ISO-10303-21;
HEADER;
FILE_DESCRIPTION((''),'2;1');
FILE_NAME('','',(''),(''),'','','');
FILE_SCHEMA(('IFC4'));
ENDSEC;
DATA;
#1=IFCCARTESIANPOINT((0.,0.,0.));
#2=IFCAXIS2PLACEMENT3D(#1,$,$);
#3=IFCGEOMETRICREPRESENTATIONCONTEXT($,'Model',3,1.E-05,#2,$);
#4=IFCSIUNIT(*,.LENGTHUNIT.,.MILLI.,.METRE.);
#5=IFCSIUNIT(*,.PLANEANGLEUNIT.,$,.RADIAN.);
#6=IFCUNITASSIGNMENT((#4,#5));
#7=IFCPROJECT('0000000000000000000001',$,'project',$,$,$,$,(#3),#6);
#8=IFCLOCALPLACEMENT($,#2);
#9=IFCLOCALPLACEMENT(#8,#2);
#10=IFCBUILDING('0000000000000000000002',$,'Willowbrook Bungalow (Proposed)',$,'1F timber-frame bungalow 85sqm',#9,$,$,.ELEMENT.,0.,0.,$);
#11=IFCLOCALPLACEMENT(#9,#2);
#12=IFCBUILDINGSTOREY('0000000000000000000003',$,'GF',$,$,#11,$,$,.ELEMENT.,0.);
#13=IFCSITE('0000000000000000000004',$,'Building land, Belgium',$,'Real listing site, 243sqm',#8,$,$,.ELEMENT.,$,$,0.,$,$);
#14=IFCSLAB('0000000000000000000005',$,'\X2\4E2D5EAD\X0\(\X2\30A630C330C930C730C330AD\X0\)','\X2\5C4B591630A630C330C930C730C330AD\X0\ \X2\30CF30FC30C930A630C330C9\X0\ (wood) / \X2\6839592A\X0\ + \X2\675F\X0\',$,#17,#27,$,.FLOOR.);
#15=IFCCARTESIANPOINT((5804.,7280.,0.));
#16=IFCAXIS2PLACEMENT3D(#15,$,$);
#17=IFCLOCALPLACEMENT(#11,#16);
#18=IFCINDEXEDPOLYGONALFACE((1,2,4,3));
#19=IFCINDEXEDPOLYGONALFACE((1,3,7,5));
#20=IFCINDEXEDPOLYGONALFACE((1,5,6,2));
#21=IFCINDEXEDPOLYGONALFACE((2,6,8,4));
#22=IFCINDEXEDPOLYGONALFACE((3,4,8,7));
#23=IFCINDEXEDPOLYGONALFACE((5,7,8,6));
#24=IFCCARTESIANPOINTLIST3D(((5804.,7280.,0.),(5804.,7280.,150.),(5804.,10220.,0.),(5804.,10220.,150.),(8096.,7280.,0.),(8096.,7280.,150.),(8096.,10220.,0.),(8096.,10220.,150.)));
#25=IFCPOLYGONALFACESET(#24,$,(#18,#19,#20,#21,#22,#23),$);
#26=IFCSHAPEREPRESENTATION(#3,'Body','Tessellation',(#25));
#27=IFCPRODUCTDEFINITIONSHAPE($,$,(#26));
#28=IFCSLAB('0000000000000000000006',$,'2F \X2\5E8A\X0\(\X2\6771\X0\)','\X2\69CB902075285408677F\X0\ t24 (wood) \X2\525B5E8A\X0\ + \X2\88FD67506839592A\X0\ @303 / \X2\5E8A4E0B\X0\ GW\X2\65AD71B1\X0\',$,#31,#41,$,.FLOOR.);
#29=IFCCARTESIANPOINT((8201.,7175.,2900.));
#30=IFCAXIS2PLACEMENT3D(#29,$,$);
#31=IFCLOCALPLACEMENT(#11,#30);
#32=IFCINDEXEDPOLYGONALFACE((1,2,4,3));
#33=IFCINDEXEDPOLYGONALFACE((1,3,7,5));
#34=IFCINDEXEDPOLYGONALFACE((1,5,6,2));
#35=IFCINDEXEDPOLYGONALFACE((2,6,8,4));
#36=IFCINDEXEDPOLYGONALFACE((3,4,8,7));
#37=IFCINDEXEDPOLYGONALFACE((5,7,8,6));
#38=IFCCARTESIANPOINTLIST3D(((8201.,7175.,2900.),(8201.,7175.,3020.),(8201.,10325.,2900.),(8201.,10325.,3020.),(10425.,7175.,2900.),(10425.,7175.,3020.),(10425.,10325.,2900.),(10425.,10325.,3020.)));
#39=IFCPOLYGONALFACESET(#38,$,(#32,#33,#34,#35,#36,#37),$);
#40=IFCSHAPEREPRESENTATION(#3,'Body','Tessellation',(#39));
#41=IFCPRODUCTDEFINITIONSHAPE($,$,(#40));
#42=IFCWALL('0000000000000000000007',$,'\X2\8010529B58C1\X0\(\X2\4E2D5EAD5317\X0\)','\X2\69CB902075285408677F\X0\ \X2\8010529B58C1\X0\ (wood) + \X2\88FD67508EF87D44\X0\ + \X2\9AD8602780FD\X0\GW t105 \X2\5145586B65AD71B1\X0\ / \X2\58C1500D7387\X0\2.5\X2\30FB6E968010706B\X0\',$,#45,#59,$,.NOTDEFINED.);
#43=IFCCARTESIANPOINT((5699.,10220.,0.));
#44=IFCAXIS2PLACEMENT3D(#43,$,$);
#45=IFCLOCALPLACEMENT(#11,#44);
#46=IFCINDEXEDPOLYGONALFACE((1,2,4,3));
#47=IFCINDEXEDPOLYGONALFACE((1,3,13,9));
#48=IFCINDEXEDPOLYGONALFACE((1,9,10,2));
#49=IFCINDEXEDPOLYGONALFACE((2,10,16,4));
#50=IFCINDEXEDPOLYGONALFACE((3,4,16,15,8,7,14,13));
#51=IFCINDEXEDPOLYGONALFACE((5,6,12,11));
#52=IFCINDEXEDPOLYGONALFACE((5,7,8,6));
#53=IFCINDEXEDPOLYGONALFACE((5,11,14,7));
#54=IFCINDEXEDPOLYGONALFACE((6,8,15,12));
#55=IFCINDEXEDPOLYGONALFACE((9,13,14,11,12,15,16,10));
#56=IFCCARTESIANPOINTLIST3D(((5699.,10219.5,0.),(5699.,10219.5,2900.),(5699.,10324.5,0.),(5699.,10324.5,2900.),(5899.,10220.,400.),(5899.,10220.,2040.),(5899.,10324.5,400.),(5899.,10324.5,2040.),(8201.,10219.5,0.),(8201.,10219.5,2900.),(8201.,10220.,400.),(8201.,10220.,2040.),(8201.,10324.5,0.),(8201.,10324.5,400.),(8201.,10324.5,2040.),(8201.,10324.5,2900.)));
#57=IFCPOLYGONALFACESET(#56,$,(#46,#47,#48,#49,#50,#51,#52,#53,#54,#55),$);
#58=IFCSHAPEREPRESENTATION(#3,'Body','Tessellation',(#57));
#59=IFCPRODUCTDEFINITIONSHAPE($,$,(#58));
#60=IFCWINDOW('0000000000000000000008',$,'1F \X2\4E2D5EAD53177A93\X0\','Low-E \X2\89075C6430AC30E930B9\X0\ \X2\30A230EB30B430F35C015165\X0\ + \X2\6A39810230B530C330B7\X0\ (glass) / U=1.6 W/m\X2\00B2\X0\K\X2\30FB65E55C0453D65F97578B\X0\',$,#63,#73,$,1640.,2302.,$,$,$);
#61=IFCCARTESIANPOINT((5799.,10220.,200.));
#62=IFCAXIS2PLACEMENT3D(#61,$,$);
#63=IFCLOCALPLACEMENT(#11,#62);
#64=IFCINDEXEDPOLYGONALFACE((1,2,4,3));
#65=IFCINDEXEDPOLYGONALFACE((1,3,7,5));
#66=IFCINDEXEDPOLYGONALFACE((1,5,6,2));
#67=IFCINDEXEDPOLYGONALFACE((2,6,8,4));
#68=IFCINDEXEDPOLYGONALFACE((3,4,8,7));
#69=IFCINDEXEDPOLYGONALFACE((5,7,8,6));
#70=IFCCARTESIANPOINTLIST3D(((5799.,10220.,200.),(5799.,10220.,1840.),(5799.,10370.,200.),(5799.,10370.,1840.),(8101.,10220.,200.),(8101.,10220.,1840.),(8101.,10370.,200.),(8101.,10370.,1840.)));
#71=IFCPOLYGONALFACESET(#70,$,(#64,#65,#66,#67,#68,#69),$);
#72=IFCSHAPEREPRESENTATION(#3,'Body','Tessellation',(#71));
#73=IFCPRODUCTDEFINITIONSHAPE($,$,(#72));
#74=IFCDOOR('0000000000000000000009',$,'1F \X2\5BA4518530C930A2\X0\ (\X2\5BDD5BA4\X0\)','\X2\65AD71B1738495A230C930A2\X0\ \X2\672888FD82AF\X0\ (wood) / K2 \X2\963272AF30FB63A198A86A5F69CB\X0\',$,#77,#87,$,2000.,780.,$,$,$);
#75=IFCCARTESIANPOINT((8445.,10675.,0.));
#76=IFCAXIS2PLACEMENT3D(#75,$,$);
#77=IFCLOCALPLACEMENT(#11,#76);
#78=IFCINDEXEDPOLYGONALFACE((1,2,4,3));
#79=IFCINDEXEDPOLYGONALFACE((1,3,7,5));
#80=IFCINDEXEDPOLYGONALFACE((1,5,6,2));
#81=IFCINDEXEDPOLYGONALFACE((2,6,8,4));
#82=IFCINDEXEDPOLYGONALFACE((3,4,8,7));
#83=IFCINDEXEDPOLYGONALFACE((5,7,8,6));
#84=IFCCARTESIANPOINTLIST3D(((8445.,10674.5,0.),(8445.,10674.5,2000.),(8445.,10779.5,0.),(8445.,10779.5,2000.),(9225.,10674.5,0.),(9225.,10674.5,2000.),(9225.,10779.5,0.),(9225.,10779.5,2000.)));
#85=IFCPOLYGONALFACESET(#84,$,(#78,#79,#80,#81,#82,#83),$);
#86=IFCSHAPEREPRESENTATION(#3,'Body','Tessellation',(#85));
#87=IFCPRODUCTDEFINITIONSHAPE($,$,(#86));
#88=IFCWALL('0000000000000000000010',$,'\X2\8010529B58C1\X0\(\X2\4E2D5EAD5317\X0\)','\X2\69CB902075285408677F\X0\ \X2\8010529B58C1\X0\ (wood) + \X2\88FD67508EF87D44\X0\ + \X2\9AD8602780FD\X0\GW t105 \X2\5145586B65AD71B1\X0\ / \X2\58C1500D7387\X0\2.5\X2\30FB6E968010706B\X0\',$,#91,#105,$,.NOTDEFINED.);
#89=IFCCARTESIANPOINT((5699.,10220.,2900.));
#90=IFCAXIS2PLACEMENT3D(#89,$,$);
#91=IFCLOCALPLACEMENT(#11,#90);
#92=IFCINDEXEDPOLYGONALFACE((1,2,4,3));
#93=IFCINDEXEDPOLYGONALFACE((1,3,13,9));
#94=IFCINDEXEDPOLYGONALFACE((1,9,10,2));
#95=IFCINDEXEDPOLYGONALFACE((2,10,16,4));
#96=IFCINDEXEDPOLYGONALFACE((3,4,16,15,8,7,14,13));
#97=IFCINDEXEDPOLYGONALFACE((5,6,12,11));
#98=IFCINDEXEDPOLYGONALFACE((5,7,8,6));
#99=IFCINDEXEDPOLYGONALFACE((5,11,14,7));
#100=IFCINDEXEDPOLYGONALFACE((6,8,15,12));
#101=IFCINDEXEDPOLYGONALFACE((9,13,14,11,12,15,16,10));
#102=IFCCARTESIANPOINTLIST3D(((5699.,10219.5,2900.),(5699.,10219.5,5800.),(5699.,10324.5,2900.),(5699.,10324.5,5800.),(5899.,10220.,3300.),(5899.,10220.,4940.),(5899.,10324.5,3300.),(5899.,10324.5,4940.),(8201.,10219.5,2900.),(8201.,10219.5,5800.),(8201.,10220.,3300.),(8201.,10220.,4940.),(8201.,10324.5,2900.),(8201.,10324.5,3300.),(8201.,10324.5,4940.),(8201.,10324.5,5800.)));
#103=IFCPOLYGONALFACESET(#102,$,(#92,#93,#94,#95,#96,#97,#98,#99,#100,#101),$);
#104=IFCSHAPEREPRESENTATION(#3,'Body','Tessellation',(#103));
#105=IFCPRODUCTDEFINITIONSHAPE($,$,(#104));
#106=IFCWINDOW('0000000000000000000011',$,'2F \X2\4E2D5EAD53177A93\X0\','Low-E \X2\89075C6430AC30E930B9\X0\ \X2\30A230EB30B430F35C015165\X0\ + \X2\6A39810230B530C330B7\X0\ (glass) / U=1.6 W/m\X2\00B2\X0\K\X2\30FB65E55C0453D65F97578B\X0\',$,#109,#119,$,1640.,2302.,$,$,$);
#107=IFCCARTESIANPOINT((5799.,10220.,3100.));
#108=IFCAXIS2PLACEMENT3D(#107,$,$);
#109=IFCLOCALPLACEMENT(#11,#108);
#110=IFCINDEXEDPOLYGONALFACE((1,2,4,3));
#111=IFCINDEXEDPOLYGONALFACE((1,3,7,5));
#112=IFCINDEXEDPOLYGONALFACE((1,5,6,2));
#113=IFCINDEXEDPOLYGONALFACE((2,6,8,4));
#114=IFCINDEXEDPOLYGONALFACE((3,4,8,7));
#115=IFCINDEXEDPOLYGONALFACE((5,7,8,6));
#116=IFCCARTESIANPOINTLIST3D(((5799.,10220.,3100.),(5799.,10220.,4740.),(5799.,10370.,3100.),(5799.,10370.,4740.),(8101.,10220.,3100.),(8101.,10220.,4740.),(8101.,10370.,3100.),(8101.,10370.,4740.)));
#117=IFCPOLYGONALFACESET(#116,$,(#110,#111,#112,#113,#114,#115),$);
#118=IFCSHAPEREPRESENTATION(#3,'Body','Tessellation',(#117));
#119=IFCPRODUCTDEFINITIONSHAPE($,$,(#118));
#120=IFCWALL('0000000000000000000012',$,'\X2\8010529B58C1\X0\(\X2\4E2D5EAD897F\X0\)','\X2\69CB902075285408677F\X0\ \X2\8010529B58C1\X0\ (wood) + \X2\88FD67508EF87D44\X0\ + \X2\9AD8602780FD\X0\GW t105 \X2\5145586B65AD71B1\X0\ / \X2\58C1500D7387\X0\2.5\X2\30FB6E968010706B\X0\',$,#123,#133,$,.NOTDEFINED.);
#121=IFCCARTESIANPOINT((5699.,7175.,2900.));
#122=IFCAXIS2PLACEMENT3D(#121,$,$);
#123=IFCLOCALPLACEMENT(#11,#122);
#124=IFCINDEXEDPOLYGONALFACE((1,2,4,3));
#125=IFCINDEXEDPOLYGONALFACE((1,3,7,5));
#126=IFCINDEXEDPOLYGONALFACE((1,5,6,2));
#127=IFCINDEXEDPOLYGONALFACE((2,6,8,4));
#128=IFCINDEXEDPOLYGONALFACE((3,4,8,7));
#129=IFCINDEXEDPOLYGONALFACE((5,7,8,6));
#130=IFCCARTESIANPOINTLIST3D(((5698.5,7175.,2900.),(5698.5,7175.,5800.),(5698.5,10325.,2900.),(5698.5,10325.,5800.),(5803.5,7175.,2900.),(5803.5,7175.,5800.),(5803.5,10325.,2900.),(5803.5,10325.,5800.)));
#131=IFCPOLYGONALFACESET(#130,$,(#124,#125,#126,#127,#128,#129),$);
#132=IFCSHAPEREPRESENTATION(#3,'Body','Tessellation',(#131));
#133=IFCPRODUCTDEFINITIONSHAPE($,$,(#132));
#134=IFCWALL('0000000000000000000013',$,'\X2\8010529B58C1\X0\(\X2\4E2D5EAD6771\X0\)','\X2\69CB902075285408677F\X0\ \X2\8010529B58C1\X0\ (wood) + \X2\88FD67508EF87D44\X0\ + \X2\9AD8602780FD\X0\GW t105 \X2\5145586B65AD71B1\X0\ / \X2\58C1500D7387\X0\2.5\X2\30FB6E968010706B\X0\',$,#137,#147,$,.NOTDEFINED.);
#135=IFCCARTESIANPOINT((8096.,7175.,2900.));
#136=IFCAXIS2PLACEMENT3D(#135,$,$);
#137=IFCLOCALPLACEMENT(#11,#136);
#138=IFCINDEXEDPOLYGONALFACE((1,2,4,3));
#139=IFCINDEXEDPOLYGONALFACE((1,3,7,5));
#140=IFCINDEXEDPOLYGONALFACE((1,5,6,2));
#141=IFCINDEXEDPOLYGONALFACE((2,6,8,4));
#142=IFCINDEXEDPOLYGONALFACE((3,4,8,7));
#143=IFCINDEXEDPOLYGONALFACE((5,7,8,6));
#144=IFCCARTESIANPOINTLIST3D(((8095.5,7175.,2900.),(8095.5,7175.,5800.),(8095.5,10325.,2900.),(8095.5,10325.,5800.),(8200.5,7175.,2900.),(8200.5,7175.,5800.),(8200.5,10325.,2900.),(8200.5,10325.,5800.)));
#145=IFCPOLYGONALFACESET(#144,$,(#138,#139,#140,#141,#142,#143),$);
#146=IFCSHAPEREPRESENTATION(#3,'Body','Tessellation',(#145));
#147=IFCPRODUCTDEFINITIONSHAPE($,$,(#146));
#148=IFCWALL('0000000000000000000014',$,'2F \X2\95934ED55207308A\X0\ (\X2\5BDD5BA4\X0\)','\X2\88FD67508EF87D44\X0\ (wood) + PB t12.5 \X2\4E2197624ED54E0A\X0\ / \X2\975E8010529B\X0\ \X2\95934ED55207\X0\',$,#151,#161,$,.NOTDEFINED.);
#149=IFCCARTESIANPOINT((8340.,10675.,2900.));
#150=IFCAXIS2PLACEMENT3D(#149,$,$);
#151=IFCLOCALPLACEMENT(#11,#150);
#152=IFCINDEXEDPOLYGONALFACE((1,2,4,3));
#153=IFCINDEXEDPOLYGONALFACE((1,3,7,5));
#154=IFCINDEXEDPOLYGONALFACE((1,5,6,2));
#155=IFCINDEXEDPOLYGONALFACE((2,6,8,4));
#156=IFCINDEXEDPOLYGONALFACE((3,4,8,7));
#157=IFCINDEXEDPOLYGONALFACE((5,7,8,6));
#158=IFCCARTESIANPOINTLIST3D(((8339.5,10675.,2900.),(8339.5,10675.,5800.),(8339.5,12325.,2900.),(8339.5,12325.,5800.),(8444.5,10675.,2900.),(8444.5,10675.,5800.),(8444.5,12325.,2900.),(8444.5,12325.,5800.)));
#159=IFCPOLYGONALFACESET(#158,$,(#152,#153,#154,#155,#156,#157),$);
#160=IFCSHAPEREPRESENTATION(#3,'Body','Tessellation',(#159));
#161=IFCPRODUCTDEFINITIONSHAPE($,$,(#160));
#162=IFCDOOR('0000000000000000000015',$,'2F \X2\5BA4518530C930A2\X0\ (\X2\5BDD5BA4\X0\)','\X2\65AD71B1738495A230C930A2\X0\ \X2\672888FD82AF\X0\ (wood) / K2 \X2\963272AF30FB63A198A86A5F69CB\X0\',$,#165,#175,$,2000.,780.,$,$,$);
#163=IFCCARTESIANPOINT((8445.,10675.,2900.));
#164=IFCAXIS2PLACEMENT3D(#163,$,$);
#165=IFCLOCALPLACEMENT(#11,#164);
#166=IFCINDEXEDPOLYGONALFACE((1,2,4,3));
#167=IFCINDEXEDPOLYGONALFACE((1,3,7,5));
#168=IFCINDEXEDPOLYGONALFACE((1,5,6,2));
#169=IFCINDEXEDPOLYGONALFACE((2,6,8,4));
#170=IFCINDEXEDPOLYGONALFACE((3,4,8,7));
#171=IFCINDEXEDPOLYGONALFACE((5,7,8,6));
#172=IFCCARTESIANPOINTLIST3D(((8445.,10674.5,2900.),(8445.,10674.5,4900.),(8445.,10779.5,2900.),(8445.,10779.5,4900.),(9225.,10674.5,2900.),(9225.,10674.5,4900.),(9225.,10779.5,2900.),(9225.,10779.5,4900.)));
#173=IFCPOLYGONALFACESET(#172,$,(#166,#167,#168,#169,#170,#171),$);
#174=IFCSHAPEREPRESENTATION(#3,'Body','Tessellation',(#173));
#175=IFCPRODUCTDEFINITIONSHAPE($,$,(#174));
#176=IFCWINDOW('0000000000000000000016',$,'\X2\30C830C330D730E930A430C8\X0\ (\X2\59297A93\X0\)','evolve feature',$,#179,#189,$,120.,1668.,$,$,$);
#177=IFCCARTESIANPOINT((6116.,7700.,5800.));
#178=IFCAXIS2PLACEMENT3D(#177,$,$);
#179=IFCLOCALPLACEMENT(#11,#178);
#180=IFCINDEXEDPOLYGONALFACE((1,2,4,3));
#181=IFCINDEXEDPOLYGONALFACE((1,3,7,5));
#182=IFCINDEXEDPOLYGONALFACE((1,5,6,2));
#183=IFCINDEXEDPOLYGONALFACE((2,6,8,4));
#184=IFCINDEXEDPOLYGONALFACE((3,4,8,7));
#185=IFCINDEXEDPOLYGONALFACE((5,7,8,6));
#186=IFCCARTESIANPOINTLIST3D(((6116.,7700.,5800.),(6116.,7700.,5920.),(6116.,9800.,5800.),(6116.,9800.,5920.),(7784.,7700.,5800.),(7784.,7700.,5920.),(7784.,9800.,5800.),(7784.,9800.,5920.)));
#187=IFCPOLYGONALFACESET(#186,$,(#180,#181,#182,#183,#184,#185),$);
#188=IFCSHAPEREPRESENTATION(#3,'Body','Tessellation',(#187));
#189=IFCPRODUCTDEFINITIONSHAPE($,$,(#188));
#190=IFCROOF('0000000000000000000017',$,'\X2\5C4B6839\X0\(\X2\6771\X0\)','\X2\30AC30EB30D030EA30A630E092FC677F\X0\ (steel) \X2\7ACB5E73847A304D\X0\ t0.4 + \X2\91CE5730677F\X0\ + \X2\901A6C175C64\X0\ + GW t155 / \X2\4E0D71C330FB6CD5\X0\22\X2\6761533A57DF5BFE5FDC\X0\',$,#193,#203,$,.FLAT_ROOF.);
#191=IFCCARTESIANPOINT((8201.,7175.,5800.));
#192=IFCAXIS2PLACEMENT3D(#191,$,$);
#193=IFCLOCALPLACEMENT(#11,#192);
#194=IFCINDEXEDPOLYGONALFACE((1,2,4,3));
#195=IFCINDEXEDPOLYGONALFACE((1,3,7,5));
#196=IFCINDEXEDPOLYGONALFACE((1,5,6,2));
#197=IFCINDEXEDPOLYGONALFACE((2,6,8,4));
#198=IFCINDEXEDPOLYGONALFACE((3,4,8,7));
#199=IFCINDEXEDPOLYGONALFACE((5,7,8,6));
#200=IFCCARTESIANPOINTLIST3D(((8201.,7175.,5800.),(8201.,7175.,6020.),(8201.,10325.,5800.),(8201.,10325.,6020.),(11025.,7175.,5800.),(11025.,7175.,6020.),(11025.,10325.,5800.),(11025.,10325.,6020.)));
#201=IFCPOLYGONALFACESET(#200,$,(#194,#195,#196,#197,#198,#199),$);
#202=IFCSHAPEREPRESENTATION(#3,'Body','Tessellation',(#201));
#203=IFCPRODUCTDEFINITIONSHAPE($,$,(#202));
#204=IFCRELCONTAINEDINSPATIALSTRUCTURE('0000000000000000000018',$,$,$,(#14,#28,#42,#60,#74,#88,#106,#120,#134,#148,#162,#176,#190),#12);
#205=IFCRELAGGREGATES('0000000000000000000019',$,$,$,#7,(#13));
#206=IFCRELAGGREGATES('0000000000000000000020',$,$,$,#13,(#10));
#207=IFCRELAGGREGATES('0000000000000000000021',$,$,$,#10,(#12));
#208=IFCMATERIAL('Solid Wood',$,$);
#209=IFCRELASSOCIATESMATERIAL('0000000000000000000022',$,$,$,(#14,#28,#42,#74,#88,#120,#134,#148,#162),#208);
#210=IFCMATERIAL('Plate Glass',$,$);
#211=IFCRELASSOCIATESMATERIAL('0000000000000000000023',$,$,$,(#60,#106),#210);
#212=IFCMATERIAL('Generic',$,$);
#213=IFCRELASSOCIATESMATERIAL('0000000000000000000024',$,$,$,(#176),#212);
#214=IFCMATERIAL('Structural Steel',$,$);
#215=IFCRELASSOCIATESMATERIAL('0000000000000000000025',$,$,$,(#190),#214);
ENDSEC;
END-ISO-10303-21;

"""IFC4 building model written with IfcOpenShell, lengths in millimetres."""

from ifc_helpers import new_model, si_unit, frame, frame_2d, origin, place, context, project, spatial, rectangle, extrude, material, element, fill, save


model = new_model("IFC4")

# Units and contexts
model_context = context("Model", 3, precision=1e-05, world=origin())
ifc_project = project(units=[si_unit("LENGTHUNIT", "METRE", prefix="MILLI"), si_unit("PLANEANGLEUNIT", "RADIAN")], contexts=[model_context])

# Site, building, storey
site_placement = place(None, origin())
site = spatial("IfcSite", under=ifc_project, at=site_placement, Name="Building land, Belgium", ObjectType="Real listing site, 243sqm", CompositionType="ELEMENT", RefElevation=0.0)
building_placement = place(site_placement, origin())
building = spatial("IfcBuilding", under=site, at=building_placement, Name="Willowbrook Bungalow (Proposed)", ObjectType="1F timber-frame bungalow 85sqm", CompositionType="ELEMENT", ElevationOfRefHeight=0.0, ElevationOfTerrain=0.0)
storey_placement = place(building_placement, origin())
storey = spatial("IfcBuildingStorey", under=building, at=storey_placement, Name="GF", CompositionType="ELEMENT", Elevation=0.0)

# Slabs
ifc_material_1 = material(Name="Solid Wood")
slab_1_placement = place(storey_placement, frame((5804.0, 7280.0, 0.0)))
element("IfcSlab", 1, at=slab_1_placement, inside=storey, material=ifc_material_1, Name="中庭(ウッドデッキ)", Description="屋外ウッドデッキ ハードウッド (wood) / 根太 + 束", PredefinedType="FLOOR", context=model_context, shape_type="SweptSolid", body=[
    extrude(rectangle(XDim=2292.0, YDim=2940.0, at=frame_2d((1146.0, 1470.0))), frame((5804.0, 7280.0, 0.0)), (0.0, 0.0, 1.0), 150.0),
])
slab_2_placement = place(storey_placement, frame((8201.0, 7175.0, 2900.0)))
element("IfcSlab", 2, at=slab_2_placement, inside=storey, material=ifc_material_1, Name="2F 床(東)", Description="構造用合板 t24 (wood) 剛床 + 製材根太 @303 / 床下 GW断熱", PredefinedType="FLOOR", context=model_context, shape_type="SweptSolid", body=[
    extrude(rectangle(XDim=2224.0, YDim=3150.0, at=frame_2d((1112.0, 1575.0))), frame((8201.0, 7175.0, 2900.0)), (0.0, 0.0, 1.0), 120.0),
])

# Wall, opening, window
wall_1_placement = place(storey_placement, frame((5699.0, 10220.0, 0.0)))
wall_1 = element("IfcWall", 3, at=wall_1_placement, inside=storey, material=ifc_material_1, Name="耐力壁(中庭北)", Description="構造用合板 耐力壁 (wood) + 製材軸組 + 高性能GW t105 充填断熱 / 壁倍率2.5・準耐火", PredefinedType="NOTDEFINED", context=model_context, shape_type="SweptSolid", body=[
    extrude(rectangle(XDim=2502.0, YDim=105.0, at=frame_2d((1251.0, 52.0))), frame((5699.0, 10220.0, 0.0)), (0.0, 0.0, 1.0), 2900.0),
])
opening_1_placement = place(storey_placement, frame((5799.0, 10220.0, 200.0)))
opening_1 = element("IfcOpeningElement", 4, at=opening_1_placement, cuts=wall_1, PredefinedType="NOTDEFINED", context=model_context, shape_type="SweptSolid", body=[
    extrude(rectangle(XDim=2302.0, YDim=150.0, at=frame_2d((1151.0, 75.0))), frame((5799.0, 10220.0, 200.0)), (0.0, 0.0, 1.0), 1640.0),
])
ifc_material_2 = material(Name="Plate Glass")
window_1_placement = place(storey_placement, frame((5799.0, 10220.0, 200.0)))
window_1 = element("IfcWindow", 5, at=window_1_placement, inside=storey, material=ifc_material_2, Name="1F 中庭北窓", Description="Low-E 複層ガラス アルゴン封入 + 樹脂サッシ (glass) / U=1.6 W/m²K・日射取得型", OverallHeight=1640.0, OverallWidth=2302.0, context=model_context, shape_type="SweptSolid", body=[
    extrude(rectangle(XDim=2302.0, YDim=150.0, at=frame_2d((1151.0, 75.0))), frame((5799.0, 10220.0, 200.0)), (0.0, 0.0, 1.0), 1640.0),
])
fill(opening_1, window_1)

# Door
door_1_placement = place(storey_placement, frame((8445.0, 10675.0, 0.0)))
element("IfcDoor", 6, at=door_1_placement, inside=storey, material=ifc_material_1, Name="1F 室内ドア (寝室)", Description="断熱玄関ドア 木製芯 (wood) / K2 防犯・採風機構", OverallHeight=2000.0, OverallWidth=780.0, context=model_context, shape_type="SweptSolid", body=[
    extrude(rectangle(XDim=780.0, YDim=105.0, at=frame_2d((390.0, 52.0))), frame((8445.0, 10675.0, 0.0)), (0.0, 0.0, 1.0), 2000.0),
])

# Wall, opening, window
wall_2_placement = place(storey_placement, frame((5699.0, 10220.0, 2900.0)))
wall_2 = element("IfcWall", 7, at=wall_2_placement, inside=storey, material=ifc_material_1, Name="耐力壁(中庭北)", Description="構造用合板 耐力壁 (wood) + 製材軸組 + 高性能GW t105 充填断熱 / 壁倍率2.5・準耐火", PredefinedType="NOTDEFINED", context=model_context, shape_type="SweptSolid", body=[
    extrude(rectangle(XDim=2502.0, YDim=105.0, at=frame_2d((1251.0, 52.0))), frame((5699.0, 10220.0, 2900.0)), (0.0, 0.0, 1.0), 2900.0),
])
opening_2_placement = place(storey_placement, frame((5799.0, 10220.0, 3100.0)))
opening_2 = element("IfcOpeningElement", 8, at=opening_2_placement, cuts=wall_2, PredefinedType="NOTDEFINED", context=model_context, shape_type="SweptSolid", body=[
    extrude(rectangle(XDim=2302.0, YDim=150.0, at=frame_2d((1151.0, 75.0))), frame((5799.0, 10220.0, 3100.0)), (0.0, 0.0, 1.0), 1640.0),
])
window_2_placement = place(storey_placement, frame((5799.0, 10220.0, 3100.0)))
window_2 = element("IfcWindow", 9, at=window_2_placement, inside=storey, material=ifc_material_2, Name="2F 中庭北窓", Description="Low-E 複層ガラス アルゴン封入 + 樹脂サッシ (glass) / U=1.6 W/m²K・日射取得型", OverallHeight=1640.0, OverallWidth=2302.0, context=model_context, shape_type="SweptSolid", body=[
    extrude(rectangle(XDim=2302.0, YDim=150.0, at=frame_2d((1151.0, 75.0))), frame((5799.0, 10220.0, 3100.0)), (0.0, 0.0, 1.0), 1640.0),
])
fill(opening_2, window_2)

# Walls
wall_3_placement = place(storey_placement, frame((5699.0, 7175.0, 2900.0)))
element("IfcWall", 10, at=wall_3_placement, inside=storey, material=ifc_material_1, Name="耐力壁(中庭西)", Description="構造用合板 耐力壁 (wood) + 製材軸組 + 高性能GW t105 充填断熱 / 壁倍率2.5・準耐火", PredefinedType="NOTDEFINED", context=model_context, shape_type="SweptSolid", body=[
    extrude(rectangle(XDim=105.0, YDim=3150.0, at=frame_2d((52.0, 1575.0))), frame((5699.0, 7175.0, 2900.0)), (0.0, 0.0, 1.0), 2900.0),
])
wall_4_placement = place(storey_placement, frame((8096.0, 7175.0, 2900.0)))
element("IfcWall", 11, at=wall_4_placement, inside=storey, material=ifc_material_1, Name="耐力壁(中庭東)", Description="構造用合板 耐力壁 (wood) + 製材軸組 + 高性能GW t105 充填断熱 / 壁倍率2.5・準耐火", PredefinedType="NOTDEFINED", context=model_context, shape_type="SweptSolid", body=[
    extrude(rectangle(XDim=105.0, YDim=3150.0, at=frame_2d((52.0, 1575.0))), frame((8096.0, 7175.0, 2900.0)), (0.0, 0.0, 1.0), 2900.0),
])
wall_5_placement = place(storey_placement, frame((8340.0, 10675.0, 2900.0)))
element("IfcWall", 12, at=wall_5_placement, inside=storey, material=ifc_material_1, Name="2F 間仕切り (寝室)", Description="製材軸組 (wood) + PB t12.5 両面仕上 / 非耐力 間仕切", PredefinedType="NOTDEFINED", context=model_context, shape_type="SweptSolid", body=[
    extrude(rectangle(XDim=105.0, YDim=1650.0, at=frame_2d((52.0, 825.0))), frame((8340.0, 10675.0, 2900.0)), (0.0, 0.0, 1.0), 2900.0),
])

# Door
door_2_placement = place(storey_placement, frame((8445.0, 10675.0, 2900.0)))
element("IfcDoor", 13, at=door_2_placement, inside=storey, material=ifc_material_1, Name="2F 室内ドア (寝室)", Description="断熱玄関ドア 木製芯 (wood) / K2 防犯・採風機構", OverallHeight=2000.0, OverallWidth=780.0, context=model_context, shape_type="SweptSolid", body=[
    extrude(rectangle(XDim=780.0, YDim=105.0, at=frame_2d((390.0, 52.0))), frame((8445.0, 10675.0, 2900.0)), (0.0, 0.0, 1.0), 2000.0),
])

# Window
ifc_material_3 = material(Name="Generic")
window_3_placement = place(storey_placement, frame((6116.0, 7700.0, 5800.0)))
element("IfcWindow", 14, at=window_3_placement, inside=storey, material=ifc_material_3, Name="トップライト (天窓)", Description="evolve feature", OverallHeight=120.0, OverallWidth=1668.0, context=model_context, shape_type="SweptSolid", body=[
    extrude(rectangle(XDim=1668.0, YDim=2100.0, at=frame_2d((834.0, 1050.0))), frame((6116.0, 7700.0, 5800.0)), (0.0, 0.0, 1.0), 120.0),
])

# Roof
ifc_material_4 = material(Name="Structural Steel")
roof_placement = place(storey_placement, frame((8201.0, 7175.0, 5800.0)))
element("IfcRoof", 15, at=roof_placement, inside=storey, material=ifc_material_4, Name="屋根(東)", Description="ガルバリウム鋼板 (steel) 立平葺き t0.4 + 野地板 + 通気層 + GW t155 / 不燃・法22条区域対応", PredefinedType="FLAT_ROOF", context=model_context, shape_type="SweptSolid", body=[
    extrude(rectangle(XDim=2824.0, YDim=3150.0, at=frame_2d((1412.0, 1575.0))), frame((8201.0, 7175.0, 5800.0)), (0.0, 0.0, 1.0), 220.0),
])

save(model, "model.ifc")
